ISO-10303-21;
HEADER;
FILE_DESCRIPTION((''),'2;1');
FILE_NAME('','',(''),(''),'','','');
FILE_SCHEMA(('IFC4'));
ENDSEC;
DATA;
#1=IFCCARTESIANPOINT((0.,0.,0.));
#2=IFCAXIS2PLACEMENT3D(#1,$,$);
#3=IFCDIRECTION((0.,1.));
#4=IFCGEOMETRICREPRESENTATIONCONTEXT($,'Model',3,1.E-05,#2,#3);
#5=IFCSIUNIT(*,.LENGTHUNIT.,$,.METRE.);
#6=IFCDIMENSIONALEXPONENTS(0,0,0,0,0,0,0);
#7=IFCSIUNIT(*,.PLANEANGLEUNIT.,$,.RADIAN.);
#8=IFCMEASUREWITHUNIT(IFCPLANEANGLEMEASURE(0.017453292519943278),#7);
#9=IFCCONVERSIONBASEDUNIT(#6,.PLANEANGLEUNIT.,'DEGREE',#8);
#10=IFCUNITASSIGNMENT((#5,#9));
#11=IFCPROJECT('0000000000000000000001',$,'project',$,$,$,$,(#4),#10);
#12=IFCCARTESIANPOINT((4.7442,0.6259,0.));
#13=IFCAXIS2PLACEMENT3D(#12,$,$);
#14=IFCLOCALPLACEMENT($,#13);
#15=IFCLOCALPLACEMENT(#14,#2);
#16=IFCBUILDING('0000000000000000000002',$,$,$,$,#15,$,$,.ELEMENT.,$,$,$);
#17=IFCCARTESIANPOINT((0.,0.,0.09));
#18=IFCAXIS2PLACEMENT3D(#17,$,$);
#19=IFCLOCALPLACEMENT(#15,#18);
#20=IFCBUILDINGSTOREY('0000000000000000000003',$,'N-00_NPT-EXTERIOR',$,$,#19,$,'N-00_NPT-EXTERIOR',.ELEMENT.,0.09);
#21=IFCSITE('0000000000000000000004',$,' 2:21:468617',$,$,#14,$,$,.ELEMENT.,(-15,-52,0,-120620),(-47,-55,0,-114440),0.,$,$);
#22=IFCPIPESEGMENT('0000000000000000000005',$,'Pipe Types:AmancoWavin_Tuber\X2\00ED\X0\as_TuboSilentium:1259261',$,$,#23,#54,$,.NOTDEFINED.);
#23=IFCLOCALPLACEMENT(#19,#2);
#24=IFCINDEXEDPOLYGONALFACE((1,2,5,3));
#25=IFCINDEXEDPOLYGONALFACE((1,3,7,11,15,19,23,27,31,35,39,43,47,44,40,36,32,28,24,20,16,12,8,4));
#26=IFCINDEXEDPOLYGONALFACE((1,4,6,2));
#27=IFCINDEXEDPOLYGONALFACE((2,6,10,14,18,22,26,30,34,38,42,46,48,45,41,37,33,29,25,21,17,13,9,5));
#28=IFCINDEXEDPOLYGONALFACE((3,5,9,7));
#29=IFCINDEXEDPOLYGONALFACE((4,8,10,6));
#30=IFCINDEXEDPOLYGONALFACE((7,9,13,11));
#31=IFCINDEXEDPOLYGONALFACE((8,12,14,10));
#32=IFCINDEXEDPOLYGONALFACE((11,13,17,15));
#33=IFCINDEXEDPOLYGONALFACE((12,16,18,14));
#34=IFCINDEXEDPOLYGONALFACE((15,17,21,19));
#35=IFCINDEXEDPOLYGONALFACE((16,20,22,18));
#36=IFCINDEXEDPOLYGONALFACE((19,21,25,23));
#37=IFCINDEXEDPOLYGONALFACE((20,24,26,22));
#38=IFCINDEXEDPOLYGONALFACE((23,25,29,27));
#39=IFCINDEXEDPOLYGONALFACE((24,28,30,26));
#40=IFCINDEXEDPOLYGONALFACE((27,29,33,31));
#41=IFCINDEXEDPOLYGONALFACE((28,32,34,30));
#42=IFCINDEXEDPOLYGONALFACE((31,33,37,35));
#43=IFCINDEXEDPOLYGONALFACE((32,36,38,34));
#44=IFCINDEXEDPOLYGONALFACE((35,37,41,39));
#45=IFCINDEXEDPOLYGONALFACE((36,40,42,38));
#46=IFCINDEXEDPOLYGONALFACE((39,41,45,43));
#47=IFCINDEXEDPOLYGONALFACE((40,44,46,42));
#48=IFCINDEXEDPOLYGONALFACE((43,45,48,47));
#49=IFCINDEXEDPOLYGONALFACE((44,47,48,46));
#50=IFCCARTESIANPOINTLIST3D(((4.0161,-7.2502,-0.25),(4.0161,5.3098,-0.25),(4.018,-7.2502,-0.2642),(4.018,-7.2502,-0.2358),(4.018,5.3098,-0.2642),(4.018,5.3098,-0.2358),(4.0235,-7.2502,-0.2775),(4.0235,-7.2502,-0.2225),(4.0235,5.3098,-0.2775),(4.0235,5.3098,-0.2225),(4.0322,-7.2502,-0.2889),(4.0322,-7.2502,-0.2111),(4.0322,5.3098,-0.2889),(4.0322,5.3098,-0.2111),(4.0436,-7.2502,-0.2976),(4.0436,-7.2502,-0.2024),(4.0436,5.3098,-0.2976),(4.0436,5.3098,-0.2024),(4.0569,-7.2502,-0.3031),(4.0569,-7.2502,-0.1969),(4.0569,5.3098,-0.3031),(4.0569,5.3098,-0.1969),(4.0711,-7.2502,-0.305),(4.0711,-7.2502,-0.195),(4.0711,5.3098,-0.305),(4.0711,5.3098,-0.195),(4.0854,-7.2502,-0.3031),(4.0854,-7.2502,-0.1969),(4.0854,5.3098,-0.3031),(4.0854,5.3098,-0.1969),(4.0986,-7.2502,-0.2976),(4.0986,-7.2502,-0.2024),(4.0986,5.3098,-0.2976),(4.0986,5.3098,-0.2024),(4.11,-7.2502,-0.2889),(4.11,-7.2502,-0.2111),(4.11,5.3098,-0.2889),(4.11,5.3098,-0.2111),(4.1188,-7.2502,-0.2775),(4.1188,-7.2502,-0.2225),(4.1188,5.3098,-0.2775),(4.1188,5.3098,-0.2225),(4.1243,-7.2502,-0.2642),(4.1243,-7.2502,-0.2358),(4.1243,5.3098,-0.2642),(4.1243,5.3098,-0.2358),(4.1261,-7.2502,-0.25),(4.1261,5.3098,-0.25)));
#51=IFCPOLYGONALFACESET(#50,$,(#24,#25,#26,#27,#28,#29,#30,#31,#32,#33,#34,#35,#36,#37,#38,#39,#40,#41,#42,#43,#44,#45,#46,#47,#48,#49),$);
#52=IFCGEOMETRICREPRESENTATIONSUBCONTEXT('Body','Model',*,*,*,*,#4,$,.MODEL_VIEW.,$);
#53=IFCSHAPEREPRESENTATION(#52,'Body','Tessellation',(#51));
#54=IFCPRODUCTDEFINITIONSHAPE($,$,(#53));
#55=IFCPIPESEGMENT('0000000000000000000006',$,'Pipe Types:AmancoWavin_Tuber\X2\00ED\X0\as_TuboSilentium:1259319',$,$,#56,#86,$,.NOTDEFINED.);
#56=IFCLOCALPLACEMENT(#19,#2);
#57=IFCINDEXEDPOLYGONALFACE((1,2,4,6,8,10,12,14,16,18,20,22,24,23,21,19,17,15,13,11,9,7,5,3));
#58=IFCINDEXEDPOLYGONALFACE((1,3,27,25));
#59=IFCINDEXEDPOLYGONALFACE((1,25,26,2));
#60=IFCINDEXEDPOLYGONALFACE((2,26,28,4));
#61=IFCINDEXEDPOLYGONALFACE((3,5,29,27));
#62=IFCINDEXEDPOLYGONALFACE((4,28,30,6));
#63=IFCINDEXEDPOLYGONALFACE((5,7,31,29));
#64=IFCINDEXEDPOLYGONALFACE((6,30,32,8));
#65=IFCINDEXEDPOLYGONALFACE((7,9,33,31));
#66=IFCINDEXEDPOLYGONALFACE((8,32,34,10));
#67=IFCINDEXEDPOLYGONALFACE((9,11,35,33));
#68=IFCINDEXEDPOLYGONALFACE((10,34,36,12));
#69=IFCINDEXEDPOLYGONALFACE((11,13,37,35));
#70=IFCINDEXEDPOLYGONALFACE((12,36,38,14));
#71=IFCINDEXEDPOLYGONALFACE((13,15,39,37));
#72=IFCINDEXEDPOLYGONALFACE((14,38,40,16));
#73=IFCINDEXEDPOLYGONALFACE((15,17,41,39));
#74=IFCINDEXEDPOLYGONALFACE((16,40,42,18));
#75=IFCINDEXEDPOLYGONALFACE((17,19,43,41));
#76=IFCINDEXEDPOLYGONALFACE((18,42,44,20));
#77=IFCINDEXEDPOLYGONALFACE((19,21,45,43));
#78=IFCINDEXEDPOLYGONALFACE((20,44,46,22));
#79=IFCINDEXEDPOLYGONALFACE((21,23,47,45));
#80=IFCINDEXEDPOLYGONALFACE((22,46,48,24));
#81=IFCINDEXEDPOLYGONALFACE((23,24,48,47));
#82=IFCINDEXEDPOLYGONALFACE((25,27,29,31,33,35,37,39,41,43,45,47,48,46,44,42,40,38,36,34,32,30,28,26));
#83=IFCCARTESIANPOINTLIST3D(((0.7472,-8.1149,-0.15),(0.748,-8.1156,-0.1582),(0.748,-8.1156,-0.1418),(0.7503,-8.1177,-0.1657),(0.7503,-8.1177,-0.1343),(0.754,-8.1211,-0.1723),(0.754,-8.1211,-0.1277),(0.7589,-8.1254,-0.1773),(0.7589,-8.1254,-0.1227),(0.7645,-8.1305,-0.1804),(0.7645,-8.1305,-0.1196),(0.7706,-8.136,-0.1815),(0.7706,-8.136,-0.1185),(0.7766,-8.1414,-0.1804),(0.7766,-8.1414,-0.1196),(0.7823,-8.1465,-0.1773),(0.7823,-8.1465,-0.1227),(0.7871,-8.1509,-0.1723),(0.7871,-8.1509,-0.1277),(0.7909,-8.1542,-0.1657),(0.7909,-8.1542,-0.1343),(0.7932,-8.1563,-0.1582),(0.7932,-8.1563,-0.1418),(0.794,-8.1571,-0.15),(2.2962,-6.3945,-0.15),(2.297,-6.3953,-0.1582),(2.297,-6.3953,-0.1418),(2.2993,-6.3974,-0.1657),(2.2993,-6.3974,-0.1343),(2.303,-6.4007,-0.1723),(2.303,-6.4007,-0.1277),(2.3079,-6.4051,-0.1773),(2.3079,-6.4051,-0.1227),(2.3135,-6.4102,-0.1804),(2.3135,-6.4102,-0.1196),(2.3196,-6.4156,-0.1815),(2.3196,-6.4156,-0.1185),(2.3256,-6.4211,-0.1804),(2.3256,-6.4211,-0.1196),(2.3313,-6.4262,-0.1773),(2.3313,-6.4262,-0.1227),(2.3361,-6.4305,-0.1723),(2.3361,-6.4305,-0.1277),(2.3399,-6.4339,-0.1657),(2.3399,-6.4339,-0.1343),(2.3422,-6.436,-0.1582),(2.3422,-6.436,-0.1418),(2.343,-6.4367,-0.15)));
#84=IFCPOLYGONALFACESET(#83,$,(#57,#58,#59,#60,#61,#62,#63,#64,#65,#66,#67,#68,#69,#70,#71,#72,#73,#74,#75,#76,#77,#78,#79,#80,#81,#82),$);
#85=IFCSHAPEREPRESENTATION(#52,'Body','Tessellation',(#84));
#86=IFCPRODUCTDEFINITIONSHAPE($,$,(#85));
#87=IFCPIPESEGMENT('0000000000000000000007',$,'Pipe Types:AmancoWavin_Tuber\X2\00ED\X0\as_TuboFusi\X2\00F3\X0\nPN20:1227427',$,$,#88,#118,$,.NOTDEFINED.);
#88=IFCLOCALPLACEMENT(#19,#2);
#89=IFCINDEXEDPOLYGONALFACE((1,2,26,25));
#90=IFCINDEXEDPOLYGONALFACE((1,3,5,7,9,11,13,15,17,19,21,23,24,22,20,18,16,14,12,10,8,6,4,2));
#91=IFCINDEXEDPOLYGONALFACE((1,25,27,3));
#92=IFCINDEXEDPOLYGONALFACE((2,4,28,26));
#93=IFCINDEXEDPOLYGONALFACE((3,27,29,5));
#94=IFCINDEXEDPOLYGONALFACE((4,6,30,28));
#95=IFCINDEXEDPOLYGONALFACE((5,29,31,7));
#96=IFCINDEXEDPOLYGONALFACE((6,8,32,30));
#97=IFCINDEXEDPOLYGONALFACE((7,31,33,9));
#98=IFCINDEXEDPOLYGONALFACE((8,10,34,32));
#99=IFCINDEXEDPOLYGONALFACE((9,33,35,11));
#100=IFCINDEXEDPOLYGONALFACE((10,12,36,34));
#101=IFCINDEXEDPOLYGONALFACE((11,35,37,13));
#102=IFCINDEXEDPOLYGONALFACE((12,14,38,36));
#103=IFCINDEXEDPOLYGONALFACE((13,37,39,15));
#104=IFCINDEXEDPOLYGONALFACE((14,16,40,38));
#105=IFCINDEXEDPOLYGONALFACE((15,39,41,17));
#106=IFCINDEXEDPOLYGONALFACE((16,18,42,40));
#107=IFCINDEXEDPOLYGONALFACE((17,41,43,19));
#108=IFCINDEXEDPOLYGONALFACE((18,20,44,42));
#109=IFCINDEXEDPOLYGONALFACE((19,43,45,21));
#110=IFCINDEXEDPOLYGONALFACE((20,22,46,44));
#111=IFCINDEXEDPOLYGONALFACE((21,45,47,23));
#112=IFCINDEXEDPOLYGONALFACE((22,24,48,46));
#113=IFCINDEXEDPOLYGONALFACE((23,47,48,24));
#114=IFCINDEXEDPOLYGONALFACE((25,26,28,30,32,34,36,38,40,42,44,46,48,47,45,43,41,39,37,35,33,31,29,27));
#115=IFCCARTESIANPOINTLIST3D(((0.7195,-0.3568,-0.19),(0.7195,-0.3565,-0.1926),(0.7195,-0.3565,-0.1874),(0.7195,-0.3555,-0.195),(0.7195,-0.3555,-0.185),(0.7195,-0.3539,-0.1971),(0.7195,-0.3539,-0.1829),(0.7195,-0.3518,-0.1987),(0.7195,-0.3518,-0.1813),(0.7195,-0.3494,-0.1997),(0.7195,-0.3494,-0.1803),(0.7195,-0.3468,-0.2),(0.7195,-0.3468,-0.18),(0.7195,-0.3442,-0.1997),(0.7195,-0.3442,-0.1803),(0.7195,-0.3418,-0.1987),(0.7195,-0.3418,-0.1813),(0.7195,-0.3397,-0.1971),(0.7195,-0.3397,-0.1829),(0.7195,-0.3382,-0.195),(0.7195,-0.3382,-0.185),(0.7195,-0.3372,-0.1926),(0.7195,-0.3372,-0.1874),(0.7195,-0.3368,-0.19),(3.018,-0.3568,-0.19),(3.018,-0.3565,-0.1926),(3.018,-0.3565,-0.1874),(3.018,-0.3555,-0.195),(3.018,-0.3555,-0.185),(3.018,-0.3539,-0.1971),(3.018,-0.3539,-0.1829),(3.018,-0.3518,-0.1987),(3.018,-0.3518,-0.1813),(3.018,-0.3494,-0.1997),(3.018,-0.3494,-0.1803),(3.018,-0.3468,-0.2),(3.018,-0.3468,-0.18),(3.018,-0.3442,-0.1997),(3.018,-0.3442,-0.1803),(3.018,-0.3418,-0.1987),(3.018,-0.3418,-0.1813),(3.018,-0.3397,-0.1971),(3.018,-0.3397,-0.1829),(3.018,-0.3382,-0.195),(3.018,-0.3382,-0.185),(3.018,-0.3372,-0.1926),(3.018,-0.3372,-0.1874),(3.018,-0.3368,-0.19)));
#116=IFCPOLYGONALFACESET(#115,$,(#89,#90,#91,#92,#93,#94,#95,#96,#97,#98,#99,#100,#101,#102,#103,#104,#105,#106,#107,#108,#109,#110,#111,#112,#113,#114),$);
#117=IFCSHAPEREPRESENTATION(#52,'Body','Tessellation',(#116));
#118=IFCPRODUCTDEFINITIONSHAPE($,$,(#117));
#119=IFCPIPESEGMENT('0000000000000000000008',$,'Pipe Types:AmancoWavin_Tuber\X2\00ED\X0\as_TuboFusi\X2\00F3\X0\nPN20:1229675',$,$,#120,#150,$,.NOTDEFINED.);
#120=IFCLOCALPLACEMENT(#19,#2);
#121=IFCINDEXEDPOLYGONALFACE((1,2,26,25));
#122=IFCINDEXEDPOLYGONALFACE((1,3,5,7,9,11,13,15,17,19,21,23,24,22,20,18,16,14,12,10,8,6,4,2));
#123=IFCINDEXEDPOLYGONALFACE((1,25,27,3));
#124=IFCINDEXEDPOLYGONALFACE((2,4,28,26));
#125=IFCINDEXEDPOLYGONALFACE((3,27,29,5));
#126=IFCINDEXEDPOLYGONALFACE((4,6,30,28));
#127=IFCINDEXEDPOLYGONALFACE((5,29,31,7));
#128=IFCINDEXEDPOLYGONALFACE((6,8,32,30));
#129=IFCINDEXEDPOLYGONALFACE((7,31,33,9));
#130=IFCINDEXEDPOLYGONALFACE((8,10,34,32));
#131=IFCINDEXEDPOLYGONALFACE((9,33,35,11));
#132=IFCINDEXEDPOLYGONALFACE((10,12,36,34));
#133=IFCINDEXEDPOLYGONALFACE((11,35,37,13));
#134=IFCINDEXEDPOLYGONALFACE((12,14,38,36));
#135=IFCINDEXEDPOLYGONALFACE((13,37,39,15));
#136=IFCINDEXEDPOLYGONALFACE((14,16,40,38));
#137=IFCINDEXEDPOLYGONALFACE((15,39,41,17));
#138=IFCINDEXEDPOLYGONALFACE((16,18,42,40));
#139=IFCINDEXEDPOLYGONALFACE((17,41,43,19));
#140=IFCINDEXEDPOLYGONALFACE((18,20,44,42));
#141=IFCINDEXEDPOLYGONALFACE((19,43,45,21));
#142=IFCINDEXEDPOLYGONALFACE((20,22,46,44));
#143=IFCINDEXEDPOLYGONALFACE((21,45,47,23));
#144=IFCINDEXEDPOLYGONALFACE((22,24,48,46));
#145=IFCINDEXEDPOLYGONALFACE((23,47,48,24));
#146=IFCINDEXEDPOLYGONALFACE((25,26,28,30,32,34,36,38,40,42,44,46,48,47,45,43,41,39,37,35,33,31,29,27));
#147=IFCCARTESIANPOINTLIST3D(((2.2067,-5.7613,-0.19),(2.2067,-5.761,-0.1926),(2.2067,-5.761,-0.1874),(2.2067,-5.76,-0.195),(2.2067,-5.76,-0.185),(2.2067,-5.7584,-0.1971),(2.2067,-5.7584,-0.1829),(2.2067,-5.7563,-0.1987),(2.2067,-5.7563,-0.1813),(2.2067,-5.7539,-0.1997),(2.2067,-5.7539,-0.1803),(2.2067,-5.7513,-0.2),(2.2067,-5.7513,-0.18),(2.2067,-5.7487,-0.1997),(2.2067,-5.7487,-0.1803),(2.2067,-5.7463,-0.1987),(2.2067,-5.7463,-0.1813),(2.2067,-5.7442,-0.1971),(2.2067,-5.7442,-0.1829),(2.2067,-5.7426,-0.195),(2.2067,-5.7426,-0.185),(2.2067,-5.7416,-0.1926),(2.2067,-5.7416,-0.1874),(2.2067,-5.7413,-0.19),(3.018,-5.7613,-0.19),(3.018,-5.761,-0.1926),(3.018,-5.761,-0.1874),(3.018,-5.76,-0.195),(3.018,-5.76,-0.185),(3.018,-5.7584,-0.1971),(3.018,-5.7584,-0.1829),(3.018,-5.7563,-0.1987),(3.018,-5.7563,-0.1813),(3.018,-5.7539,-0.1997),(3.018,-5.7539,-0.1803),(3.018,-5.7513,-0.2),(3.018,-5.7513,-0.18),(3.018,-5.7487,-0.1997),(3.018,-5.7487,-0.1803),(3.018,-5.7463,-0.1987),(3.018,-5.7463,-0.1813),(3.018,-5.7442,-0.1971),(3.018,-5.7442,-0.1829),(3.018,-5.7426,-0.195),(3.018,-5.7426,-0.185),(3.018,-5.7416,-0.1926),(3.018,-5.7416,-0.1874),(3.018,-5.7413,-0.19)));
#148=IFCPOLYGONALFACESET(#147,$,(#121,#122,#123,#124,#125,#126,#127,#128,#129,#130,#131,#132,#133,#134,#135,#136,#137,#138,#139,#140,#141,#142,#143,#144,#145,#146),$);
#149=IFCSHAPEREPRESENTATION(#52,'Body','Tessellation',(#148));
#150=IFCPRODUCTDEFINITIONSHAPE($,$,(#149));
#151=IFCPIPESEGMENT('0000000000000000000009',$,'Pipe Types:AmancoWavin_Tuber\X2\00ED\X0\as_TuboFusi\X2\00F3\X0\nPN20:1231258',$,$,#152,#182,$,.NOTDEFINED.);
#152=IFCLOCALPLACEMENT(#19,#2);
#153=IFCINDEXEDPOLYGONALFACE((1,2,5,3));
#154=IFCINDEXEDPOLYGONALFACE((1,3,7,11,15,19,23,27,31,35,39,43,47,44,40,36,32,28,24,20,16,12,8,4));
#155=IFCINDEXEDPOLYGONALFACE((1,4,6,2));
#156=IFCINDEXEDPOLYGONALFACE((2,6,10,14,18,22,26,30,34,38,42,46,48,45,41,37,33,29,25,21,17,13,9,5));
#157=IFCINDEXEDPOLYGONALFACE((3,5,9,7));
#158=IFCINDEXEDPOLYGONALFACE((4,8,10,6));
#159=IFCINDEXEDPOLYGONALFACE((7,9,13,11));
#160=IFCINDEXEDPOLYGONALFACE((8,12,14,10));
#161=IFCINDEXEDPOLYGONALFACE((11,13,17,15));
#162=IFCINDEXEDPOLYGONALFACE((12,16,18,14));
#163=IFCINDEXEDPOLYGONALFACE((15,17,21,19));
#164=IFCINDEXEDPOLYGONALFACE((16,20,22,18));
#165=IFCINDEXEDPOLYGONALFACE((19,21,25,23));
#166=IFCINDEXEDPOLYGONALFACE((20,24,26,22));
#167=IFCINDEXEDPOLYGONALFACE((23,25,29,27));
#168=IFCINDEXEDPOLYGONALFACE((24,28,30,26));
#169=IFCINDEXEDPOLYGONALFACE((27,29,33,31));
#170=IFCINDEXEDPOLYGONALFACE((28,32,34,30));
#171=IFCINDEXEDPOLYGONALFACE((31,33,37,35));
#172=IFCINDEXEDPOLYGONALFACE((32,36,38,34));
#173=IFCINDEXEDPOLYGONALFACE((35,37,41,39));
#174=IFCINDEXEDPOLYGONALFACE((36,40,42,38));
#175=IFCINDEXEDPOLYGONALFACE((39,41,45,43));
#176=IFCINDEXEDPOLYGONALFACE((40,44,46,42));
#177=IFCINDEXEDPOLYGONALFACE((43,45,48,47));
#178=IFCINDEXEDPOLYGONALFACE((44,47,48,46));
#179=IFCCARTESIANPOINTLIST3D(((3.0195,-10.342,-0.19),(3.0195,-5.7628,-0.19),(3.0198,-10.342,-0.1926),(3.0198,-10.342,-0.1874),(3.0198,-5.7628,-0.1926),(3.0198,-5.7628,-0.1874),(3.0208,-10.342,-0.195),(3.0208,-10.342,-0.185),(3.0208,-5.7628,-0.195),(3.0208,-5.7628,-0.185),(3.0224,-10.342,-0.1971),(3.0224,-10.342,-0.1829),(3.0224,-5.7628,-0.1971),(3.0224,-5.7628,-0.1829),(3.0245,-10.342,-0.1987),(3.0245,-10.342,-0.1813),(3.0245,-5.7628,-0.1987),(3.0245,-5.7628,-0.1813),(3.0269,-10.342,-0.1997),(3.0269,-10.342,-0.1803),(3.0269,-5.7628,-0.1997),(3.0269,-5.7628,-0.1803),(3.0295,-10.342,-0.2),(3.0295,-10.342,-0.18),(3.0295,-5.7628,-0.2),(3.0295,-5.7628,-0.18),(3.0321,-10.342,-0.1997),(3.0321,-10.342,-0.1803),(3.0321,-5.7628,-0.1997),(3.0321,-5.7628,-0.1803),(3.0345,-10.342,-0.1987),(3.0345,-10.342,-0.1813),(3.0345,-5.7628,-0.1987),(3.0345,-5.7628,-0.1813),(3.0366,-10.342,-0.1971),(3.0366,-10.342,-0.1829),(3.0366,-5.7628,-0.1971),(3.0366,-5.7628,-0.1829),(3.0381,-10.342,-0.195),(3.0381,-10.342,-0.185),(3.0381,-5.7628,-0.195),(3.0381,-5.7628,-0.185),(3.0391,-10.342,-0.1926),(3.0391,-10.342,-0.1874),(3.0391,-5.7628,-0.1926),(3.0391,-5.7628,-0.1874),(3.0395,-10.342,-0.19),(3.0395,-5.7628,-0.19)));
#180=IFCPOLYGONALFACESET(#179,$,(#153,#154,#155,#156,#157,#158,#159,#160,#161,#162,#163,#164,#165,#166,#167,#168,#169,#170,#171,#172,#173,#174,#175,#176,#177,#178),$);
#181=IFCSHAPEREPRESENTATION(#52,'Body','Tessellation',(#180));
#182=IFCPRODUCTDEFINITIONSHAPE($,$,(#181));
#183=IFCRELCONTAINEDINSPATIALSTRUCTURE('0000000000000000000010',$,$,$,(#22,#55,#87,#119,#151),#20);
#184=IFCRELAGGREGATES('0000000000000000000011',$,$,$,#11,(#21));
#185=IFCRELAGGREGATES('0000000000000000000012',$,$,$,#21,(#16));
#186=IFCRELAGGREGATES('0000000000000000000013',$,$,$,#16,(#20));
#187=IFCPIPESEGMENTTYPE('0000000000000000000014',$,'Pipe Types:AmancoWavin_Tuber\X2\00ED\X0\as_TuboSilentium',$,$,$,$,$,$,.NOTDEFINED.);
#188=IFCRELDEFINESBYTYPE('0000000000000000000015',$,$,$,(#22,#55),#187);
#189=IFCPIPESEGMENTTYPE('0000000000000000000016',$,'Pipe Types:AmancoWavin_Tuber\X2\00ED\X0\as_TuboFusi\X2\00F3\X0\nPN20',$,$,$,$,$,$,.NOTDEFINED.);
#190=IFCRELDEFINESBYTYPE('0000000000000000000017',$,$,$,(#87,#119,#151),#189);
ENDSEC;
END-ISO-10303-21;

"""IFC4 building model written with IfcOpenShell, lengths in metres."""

from ifc_helpers import new_model, entity, si_unit, converted_unit, direction, frame, origin, place, context, subcontext, project, spatial, arc, indexed_curve, outline, extrude, type_object, element, save


model = new_model("IFC4")

# Units and contexts
model_context = context("Model", 3, precision=1e-05, world=origin(), true_north=direction((0.0, 1.0)))
body_context = subcontext(model_context, "Body", "Model", "MODEL_VIEW")
ifc_project = project(units=[si_unit("LENGTHUNIT", "METRE"), converted_unit("PLANEANGLEUNIT", "DEGREE", entity("IfcPlaneAngleMeasure", 0.017453292519943278), si_unit("PLANEANGLEUNIT", "RADIAN"), dimensions=[0, 0, 0, 0, 0, 0, 0])], contexts=[model_context])

# Site, building, storey
site_placement = place(None, frame((4.7442, 0.6259, 0.0)))
site = spatial("IfcSite", under=ifc_project, at=site_placement, Name=" 2:21:468617", CompositionType="ELEMENT", RefLatitude=(-15, -52, 0, -120620), RefLongitude=(-47, -55, 0, -114440), RefElevation=0.0)
building_placement = place(site_placement, origin())
building = spatial("IfcBuilding", under=site, at=building_placement, CompositionType="ELEMENT")
storey_placement = place(building_placement, frame((0.0, 0.0, 0.09)))
storey = spatial("IfcBuildingStorey", under=building, at=storey_placement, Name="N-00_NPT-EXTERIOR", LongName="N-00_NPT-EXTERIOR", CompositionType="ELEMENT", Elevation=0.09)

# Pipe segments
pipe_segment_type_1 = type_object("IfcPipeSegmentType", Name="Pipe Types:AmancoWavin_Tuberías_TuboSilentium", PredefinedType="NOTDEFINED")
pipe_segment_1_placement = place(storey_placement, origin())
element("IfcPipeSegment", 1, at=pipe_segment_1_placement, inside=storey, type_object=pipe_segment_type_1, Name="Pipe Types:AmancoWavin_Tuberías_TuboSilentium:1259261", PredefinedType="NOTDEFINED", context=body_context, shape_type="SweptSolid", body=[
    extrude(outline(indexed_curve([(0.055, 0.0), (0.0389, 0.0389), (0.0, 0.055), (-0.0389, 0.0389), (-0.055, 0.0), (-0.0389, -0.0389), (0.0, -0.055), (0.0389, -0.0389)], segments=[arc(1, 2, 3), arc(3, 4, 5), arc(5, 6, 7), arc(7, 8, 1)], self_intersect=False)), frame((4.0711, -7.2502, -0.25), z_axis=(0.0, 1.0, 0.0), x_axis=(-1.0, 0.0, 0.0)), (0.0, 0.0, 1.0), 12.56),
])
pipe_segment_2_placement = place(storey_placement, origin())
element("IfcPipeSegment", 2, at=pipe_segment_2_placement, inside=storey, type_object=pipe_segment_type_1, Name="Pipe Types:AmancoWavin_Tuberías_TuboSilentium:1259319", PredefinedType="NOTDEFINED", context=body_context, shape_type="SweptSolid", body=[
    extrude(outline(indexed_curve([(0.0315, 0.0), (0.0223, 0.0223), (0.0, 0.0315), (-0.0223, 0.0223), (-0.0315, 0.0), (-0.0223, -0.0223), (0.0, -0.0315), (0.0223, -0.0223)], segments=[arc(1, 2, 3), arc(3, 4, 5), arc(5, 6, 7), arc(7, 8, 1)], self_intersect=False)), frame((0.7706, -8.136, -0.15), z_axis=(0.669131, 0.743145, 0.0), x_axis=(0.743145, -0.669131, 0.0)), (0.0, 0.0, 1.0), 2.315),
])
pipe_segment_type_2 = type_object("IfcPipeSegmentType", Name="Pipe Types:AmancoWavin_Tuberías_TuboFusiónPN20", PredefinedType="NOTDEFINED")
pipe_segment_3_placement = place(storey_placement, origin())
element("IfcPipeSegment", 3, at=pipe_segment_3_placement, inside=storey, type_object=pipe_segment_type_2, Name="Pipe Types:AmancoWavin_Tuberías_TuboFusiónPN20:1227427", PredefinedType="NOTDEFINED", context=body_context, shape_type="SweptSolid", body=[
    extrude(outline(indexed_curve([(0.01, 0.0), (0.0071, 0.0071), (0.0, 0.01), (-0.0071, 0.0071), (-0.01, 0.0), (-0.0071, -0.0071), (0.0, -0.01), (0.0071, -0.0071)], segments=[arc(1, 2, 3), arc(3, 4, 5), arc(5, 6, 7), arc(7, 8, 1)], self_intersect=False)), frame((0.7195, -0.3468, -0.19), z_axis=(1.0, 0.0, 0.0), x_axis=(0.0, -1.0, 0.0)), (0.0, 0.0, 1.0), 2.2985),
])
pipe_segment_4_placement = place(storey_placement, origin())
element("IfcPipeSegment", 4, at=pipe_segment_4_placement, inside=storey, type_object=pipe_segment_type_2, Name="Pipe Types:AmancoWavin_Tuberías_TuboFusiónPN20:1229675", PredefinedType="NOTDEFINED", context=body_context, shape_type="SweptSolid", body=[
    extrude(outline(indexed_curve([(0.01, 0.0), (0.0071, 0.0071), (0.0, 0.01), (-0.0071, 0.0071), (-0.01, 0.0), (-0.0071, -0.0071), (0.0, -0.01), (0.0071, -0.0071)], segments=[arc(1, 2, 3), arc(3, 4, 5), arc(5, 6, 7), arc(7, 8, 1)], self_intersect=False)), frame((2.2067, -5.7513, -0.19), z_axis=(1.0, 0.0, 0.0), x_axis=(0.0, -1.0, 0.0)), (0.0, 0.0, 1.0), 0.8113),
])
pipe_segment_5_placement = place(storey_placement, origin())
element("IfcPipeSegment", 5, at=pipe_segment_5_placement, inside=storey, type_object=pipe_segment_type_2, Name="Pipe Types:AmancoWavin_Tuberías_TuboFusiónPN20:1231258", PredefinedType="NOTDEFINED", context=body_context, shape_type="SweptSolid", body=[
    extrude(outline(indexed_curve([(0.01, 0.0), (0.0071, 0.0071), (0.0, 0.01), (-0.0071, 0.0071), (-0.01, 0.0), (-0.0071, -0.0071), (0.0, -0.01), (0.0071, -0.0071)], segments=[arc(1, 2, 3), arc(3, 4, 5), arc(5, 6, 7), arc(7, 8, 1)], self_intersect=False)), frame((3.0295, -10.342, -0.19), z_axis=(0.0, 1.0, 0.0), x_axis=(-1.0, 0.0, 0.0)), (0.0, 0.0, 1.0), 4.5792),
])

save(model, "model.ifc")
